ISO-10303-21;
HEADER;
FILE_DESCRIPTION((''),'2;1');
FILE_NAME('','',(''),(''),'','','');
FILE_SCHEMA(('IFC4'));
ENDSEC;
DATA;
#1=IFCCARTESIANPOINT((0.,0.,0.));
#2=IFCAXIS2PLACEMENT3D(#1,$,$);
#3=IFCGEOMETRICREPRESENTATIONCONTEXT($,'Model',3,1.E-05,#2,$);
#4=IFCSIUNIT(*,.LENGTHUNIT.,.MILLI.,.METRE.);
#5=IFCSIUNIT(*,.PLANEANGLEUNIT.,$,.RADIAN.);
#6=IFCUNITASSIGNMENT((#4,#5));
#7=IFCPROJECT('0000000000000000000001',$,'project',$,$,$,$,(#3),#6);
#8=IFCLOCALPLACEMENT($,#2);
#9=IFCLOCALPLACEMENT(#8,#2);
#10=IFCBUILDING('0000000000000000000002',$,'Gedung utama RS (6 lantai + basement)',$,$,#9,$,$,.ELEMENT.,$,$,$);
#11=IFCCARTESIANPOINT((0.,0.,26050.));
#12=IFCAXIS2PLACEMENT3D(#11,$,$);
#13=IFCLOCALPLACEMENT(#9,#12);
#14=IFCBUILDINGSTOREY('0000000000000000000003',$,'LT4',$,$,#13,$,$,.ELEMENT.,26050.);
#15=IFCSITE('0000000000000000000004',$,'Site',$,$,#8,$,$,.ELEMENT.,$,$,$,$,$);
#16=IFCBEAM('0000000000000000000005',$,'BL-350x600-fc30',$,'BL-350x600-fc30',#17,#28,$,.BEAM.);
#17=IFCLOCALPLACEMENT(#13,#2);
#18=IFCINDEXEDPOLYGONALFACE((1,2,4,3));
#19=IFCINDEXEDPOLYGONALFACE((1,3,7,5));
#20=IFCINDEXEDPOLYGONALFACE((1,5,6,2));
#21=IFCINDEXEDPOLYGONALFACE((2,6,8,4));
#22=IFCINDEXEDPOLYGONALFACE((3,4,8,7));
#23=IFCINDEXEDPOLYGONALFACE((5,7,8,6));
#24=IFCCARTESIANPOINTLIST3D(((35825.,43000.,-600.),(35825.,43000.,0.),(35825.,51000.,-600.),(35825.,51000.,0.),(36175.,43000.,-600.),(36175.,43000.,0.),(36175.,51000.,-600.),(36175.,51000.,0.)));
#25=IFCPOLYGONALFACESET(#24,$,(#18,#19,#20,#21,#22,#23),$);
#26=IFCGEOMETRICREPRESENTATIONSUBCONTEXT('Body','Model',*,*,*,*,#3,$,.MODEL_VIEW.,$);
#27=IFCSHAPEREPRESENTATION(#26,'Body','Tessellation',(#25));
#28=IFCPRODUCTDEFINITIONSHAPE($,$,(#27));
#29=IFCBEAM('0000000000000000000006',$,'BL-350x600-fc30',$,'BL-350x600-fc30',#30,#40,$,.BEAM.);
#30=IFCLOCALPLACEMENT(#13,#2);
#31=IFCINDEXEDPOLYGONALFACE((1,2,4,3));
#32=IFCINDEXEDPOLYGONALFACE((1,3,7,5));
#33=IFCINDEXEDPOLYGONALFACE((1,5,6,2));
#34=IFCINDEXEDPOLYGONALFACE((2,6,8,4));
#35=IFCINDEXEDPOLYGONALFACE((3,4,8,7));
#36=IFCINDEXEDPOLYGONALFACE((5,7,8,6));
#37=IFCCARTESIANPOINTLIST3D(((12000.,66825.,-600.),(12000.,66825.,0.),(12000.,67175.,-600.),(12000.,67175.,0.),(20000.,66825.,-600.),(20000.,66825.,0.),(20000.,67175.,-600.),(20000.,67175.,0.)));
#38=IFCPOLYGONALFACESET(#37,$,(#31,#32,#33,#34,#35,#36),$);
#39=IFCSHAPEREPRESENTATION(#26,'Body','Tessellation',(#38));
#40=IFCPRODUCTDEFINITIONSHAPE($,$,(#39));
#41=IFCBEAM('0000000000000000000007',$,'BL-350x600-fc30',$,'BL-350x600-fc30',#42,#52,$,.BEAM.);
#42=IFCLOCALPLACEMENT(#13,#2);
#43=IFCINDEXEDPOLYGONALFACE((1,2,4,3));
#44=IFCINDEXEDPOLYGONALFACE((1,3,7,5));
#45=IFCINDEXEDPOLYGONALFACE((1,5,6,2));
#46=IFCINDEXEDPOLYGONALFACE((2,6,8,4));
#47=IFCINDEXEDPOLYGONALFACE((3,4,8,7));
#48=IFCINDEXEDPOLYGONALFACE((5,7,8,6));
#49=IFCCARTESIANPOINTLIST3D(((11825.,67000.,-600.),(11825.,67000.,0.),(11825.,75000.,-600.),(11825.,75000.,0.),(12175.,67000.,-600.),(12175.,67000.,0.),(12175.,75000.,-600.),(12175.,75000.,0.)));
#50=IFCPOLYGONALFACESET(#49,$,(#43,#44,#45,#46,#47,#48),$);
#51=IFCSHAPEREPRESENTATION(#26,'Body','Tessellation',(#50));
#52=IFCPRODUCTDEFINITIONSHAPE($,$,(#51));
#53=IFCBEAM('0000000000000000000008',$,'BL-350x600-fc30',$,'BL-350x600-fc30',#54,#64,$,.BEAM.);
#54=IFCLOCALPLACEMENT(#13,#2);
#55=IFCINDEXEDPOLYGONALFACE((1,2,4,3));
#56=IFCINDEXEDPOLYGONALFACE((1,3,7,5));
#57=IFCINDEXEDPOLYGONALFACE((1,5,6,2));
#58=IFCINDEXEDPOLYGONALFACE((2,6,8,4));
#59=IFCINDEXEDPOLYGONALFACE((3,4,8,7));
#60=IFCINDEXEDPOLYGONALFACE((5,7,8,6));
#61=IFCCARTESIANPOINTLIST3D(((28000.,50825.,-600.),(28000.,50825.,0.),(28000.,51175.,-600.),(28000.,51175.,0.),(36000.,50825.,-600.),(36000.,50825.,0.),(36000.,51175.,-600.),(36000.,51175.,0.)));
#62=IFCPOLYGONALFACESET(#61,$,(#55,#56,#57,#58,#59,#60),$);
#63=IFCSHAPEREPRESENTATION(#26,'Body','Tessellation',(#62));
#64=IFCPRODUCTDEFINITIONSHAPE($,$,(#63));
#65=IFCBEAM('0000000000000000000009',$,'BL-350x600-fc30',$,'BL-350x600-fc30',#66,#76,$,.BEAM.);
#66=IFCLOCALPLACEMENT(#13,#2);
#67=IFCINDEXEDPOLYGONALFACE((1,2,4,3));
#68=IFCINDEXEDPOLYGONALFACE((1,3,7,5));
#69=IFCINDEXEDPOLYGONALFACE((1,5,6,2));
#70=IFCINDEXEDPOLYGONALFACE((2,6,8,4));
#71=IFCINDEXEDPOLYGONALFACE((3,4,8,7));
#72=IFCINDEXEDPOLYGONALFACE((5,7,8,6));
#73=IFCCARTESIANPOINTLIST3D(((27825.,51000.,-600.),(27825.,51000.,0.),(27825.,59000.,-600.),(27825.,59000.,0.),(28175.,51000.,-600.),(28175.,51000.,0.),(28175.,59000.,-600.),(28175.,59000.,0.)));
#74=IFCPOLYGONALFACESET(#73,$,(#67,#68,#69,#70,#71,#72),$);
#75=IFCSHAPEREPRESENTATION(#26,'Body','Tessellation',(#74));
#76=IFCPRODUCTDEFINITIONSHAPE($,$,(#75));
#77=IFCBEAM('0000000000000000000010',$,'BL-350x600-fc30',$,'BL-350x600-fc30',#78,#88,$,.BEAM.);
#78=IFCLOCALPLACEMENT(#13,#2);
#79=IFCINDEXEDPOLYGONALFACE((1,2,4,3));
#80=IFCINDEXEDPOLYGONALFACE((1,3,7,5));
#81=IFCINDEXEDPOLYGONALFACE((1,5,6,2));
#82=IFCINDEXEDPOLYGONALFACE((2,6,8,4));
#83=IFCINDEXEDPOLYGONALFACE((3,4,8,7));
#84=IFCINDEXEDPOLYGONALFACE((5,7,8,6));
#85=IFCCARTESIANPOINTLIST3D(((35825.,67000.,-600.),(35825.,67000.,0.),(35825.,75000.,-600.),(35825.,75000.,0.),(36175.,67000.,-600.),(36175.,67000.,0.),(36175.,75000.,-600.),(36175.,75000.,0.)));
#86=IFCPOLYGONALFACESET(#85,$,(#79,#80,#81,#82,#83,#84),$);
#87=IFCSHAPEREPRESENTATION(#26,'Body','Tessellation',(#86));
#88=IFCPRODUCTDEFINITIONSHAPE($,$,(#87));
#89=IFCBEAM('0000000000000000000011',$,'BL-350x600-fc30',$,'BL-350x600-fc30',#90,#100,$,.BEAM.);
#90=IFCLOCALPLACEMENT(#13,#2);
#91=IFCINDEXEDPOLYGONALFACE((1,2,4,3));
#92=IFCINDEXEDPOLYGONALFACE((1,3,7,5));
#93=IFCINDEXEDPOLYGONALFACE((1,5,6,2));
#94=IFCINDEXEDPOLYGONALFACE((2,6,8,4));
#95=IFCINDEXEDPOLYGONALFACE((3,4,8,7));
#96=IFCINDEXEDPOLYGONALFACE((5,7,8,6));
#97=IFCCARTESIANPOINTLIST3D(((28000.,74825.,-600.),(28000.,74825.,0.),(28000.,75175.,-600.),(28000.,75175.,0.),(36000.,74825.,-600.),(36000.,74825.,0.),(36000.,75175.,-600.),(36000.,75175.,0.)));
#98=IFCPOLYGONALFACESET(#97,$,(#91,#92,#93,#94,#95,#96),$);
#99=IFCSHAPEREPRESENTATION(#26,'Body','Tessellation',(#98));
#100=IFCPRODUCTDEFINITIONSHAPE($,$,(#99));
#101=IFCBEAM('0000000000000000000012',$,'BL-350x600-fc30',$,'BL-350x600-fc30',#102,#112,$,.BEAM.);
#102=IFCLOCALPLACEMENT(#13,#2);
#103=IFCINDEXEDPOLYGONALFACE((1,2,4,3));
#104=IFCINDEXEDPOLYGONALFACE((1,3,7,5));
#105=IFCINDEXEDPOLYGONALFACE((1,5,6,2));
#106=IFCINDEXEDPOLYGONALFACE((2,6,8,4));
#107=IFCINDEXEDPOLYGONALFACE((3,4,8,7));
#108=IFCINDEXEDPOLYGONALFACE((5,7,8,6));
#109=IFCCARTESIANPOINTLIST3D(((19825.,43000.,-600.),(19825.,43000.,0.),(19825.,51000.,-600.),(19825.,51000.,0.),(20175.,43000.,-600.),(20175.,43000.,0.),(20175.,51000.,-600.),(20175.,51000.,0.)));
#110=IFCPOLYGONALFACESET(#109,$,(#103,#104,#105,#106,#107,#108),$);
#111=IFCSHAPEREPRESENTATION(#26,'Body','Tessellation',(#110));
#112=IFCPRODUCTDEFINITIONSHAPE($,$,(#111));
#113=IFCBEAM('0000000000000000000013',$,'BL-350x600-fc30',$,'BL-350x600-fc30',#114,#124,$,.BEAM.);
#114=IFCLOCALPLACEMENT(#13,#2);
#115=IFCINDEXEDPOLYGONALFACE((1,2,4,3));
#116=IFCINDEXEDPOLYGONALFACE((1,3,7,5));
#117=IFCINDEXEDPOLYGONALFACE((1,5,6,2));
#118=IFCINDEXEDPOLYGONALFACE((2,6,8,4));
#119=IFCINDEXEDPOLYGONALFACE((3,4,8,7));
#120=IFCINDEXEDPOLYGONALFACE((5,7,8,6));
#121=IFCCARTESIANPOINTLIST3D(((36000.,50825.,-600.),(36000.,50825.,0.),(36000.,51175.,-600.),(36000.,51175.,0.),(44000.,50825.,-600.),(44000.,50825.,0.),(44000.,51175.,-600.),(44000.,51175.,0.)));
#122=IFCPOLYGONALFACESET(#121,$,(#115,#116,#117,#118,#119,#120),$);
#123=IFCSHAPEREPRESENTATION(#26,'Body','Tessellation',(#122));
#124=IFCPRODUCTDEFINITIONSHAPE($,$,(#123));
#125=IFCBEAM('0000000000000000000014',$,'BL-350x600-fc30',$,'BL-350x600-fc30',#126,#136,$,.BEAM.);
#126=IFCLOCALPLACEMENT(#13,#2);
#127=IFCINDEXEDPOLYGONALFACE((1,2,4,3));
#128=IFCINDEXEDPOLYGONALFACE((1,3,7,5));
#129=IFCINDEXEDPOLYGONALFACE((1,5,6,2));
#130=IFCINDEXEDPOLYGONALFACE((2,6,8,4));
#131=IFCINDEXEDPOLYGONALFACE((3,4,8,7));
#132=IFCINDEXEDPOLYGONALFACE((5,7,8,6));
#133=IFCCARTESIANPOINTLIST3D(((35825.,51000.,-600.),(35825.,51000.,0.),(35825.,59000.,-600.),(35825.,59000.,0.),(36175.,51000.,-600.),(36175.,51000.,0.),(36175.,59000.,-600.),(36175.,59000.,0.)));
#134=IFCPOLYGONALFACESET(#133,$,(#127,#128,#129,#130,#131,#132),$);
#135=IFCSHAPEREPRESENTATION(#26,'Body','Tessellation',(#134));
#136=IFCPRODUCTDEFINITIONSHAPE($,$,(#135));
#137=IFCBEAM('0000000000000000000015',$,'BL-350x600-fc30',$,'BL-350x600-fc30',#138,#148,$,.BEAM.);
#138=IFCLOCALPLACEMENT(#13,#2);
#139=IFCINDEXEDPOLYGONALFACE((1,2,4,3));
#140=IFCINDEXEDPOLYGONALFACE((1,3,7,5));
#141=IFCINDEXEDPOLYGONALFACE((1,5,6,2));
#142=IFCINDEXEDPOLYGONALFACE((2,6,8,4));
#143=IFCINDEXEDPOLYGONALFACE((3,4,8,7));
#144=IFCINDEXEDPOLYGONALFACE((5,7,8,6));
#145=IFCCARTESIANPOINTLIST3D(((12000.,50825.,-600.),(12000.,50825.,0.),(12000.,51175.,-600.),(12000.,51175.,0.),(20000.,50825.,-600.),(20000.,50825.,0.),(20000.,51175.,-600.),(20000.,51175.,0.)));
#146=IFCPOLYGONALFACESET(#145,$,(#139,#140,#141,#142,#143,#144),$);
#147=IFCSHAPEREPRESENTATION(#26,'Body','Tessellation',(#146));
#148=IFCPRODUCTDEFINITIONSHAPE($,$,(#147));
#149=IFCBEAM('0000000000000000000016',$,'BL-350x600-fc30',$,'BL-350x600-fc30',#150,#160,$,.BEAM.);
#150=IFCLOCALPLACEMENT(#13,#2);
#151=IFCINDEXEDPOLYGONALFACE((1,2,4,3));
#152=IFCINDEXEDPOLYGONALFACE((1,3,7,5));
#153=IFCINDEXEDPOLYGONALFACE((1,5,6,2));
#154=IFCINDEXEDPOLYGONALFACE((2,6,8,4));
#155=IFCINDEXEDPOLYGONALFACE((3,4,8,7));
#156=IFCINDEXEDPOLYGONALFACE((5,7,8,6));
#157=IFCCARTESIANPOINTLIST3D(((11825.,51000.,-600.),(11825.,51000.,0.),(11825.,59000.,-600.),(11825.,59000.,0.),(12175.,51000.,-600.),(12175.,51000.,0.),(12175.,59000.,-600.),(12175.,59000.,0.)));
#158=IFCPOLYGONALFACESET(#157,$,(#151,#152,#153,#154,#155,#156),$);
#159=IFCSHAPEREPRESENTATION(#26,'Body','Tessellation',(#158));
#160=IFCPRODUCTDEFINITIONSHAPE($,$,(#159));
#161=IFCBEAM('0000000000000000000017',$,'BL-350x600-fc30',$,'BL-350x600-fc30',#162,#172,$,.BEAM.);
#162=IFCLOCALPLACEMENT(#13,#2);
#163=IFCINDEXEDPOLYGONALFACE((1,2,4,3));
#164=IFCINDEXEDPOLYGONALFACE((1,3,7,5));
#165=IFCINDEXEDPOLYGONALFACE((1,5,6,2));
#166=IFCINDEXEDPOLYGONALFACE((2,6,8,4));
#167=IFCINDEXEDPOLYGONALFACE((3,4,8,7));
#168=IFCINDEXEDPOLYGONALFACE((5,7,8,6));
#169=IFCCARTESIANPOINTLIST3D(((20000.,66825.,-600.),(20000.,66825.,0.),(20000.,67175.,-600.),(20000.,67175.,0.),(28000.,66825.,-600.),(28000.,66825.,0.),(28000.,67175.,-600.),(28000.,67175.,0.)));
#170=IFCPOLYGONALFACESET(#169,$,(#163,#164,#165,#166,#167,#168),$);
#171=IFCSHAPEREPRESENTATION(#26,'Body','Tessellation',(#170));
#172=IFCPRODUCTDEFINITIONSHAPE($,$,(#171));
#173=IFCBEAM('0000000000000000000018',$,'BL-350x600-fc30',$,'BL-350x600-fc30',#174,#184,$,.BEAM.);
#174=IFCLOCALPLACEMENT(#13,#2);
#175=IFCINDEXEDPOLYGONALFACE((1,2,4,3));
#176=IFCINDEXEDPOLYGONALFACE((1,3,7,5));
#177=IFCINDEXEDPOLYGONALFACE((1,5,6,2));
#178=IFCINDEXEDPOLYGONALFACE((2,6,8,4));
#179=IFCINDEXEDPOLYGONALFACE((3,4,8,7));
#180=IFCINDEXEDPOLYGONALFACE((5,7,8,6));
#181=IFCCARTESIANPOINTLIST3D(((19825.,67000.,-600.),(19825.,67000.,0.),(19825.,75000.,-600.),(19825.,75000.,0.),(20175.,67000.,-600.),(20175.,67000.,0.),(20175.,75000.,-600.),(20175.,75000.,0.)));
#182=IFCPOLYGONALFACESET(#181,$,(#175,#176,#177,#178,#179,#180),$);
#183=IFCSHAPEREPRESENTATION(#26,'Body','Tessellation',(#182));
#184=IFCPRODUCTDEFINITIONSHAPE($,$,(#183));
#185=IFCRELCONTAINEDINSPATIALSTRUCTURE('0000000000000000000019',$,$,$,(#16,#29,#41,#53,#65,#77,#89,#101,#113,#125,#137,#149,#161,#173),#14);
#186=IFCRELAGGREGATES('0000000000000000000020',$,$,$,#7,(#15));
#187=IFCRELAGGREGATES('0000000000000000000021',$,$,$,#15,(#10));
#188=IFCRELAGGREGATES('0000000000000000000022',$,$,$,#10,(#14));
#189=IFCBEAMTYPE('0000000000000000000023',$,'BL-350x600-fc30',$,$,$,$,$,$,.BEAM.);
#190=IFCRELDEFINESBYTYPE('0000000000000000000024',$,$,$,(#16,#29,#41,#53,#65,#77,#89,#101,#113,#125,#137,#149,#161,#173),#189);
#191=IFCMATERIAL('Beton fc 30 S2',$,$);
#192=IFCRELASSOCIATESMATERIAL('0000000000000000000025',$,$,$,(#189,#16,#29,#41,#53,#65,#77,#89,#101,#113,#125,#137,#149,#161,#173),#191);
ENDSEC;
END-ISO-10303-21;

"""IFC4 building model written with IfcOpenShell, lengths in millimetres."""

from ifc_helpers import new_model, si_unit, frame, origin, origin_2d, place, context, subcontext, project, spatial, rectangle, extrude, material, material_profile, profile_set, profile_usage, type_object, element, save


model = new_model("IFC4")

# Units and contexts
model_context = context("Model", 3, precision=1e-05, world=origin())
body_context = subcontext(model_context, "Body", "Model", "MODEL_VIEW")
ifc_project = project(units=[si_unit("LENGTHUNIT", "METRE", prefix="MILLI"), si_unit("PLANEANGLEUNIT", "RADIAN")], contexts=[model_context])

# Site, building, storey
site_placement = place(None, origin())
site = spatial("IfcSite", under=ifc_project, at=site_placement, Name="Site", CompositionType="ELEMENT")
building_placement = place(site_placement, origin())
building = spatial("IfcBuilding", under=site, at=building_placement, Name="Gedung utama RS (6 lantai + basement)", CompositionType="ELEMENT")
storey_placement = place(building_placement, frame((0.0, 0.0, 26050.0)))
storey = spatial("IfcBuildingStorey", under=building, at=storey_placement, Name="LT4", CompositionType="ELEMENT", Elevation=26050.0)

# Beams
ifc_material = material(Name="Beton fc 30 S2")
ifc_material_profile_1 = material_profile(ifc_material, rectangle(XDim=350.0, YDim=600.0, at=origin_2d()), Name="BL-350x600-fc30")
ifc_profile_set_1 = profile_set([ifc_material_profile_1], Name="BL-350x600-fc30")
ifc_profile_usage_1 = profile_usage(ifc_profile_set_1, cardinal=8)
beam_type = type_object("IfcBeamType", Name="BL-350x600-fc30", PredefinedType="BEAM", material=ifc_profile_set_1)
beam_1_placement = place(storey_placement, frame((36000.0, 43000.0, -300.0)))
element("IfcBeam", 1, at=beam_1_placement, inside=storey, type_object=beam_type, material=ifc_profile_usage_1, Name="BL-350x600-fc30", ObjectType="BL-350x600-fc30", PredefinedType="BEAM", context=body_context, shape_type="SweptSolid", body=[
    extrude(rectangle(XDim=350.0, YDim=600.0, at=origin_2d()), frame((0.0, 0.0, 0.0), z_axis=(0.0, 1.0, 0.0), x_axis=(-1.0, 0.0, 0.0)), (0.0, 0.0, 1.0), 8000.0),
])
beam_2_placement = place(storey_placement, frame((12000.0, 67000.0, -300.0)))
element("IfcBeam", 2, at=beam_2_placement, inside=storey, type_object=beam_type, material=ifc_profile_usage_1, Name="BL-350x600-fc30", ObjectType="BL-350x600-fc30", PredefinedType="BEAM", context=body_context, shape_type="SweptSolid", body=[
    extrude(rectangle(XDim=350.0, YDim=600.0, at=origin_2d()), frame((0.0, 0.0, 0.0), z_axis=(1.0, 0.0, 0.0), x_axis=(0.0, 1.0, 0.0)), (0.0, 0.0, 1.0), 8000.0),
])
beam_3_placement = place(storey_placement, frame((12000.0, 67000.0, -300.0)))
element("IfcBeam", 3, at=beam_3_placement, inside=storey, type_object=beam_type, material=ifc_profile_usage_1, Name="BL-350x600-fc30", ObjectType="BL-350x600-fc30", PredefinedType="BEAM", context=body_context, shape_type="SweptSolid", body=[
    extrude(rectangle(XDim=350.0, YDim=600.0, at=origin_2d()), frame((0.0, 0.0, 0.0), z_axis=(0.0, 1.0, 0.0), x_axis=(-1.0, 0.0, 0.0)), (0.0, 0.0, 1.0), 8000.0),
])
beam_4_placement = place(storey_placement, frame((28000.0, 51000.0, -300.0)))
element("IfcBeam", 4, at=beam_4_placement, inside=storey, type_object=beam_type, material=ifc_profile_usage_1, Name="BL-350x600-fc30", ObjectType="BL-350x600-fc30", PredefinedType="BEAM", context=body_context, shape_type="SweptSolid", body=[
    extrude(rectangle(XDim=350.0, YDim=600.0, at=origin_2d()), frame((0.0, 0.0, 0.0), z_axis=(1.0, 0.0, 0.0), x_axis=(0.0, 1.0, 0.0)), (0.0, 0.0, 1.0), 8000.0),
])
for number, where, name in (
    (5, (28000.0, 51000.0, -300.0), "BL-350x600-fc30"),
    (6, (36000.0, 67000.0, -300.0), "BL-350x600-fc30"),
):
    element("IfcBeam", number, at=place(storey_placement, frame(where)), inside=storey, type_object=beam_type, material=ifc_profile_usage_1, Name=name, ObjectType="BL-350x600-fc30", PredefinedType="BEAM", context=body_context, shape_type="SweptSolid", body=[
        extrude(rectangle(XDim=350.0, YDim=600.0, at=origin_2d()), frame((0.0, 0.0, 0.0), z_axis=(0.0, 1.0, 0.0), x_axis=(-1.0, 0.0, 0.0)), (0.0, 0.0, 1.0), 8000.0),
    ])
beam_5_placement = place(storey_placement, frame((28000.0, 75000.0, -300.0)))
element("IfcBeam", 7, at=beam_5_placement, inside=storey, type_object=beam_type, material=ifc_profile_usage_1, Name="BL-350x600-fc30", ObjectType="BL-350x600-fc30", PredefinedType="BEAM", context=body_context, shape_type="SweptSolid", body=[
    extrude(rectangle(XDim=350.0, YDim=600.0, at=origin_2d()), frame((0.0, 0.0, 0.0), z_axis=(1.0, 0.0, 0.0), x_axis=(0.0, 1.0, 0.0)), (0.0, 0.0, 1.0), 8000.0),
])
beam_6_placement = place(storey_placement, frame((20000.0, 43000.0, -300.0)))
element("IfcBeam", 8, at=beam_6_placement, inside=storey, type_object=beam_type, material=ifc_profile_usage_1, Name="BL-350x600-fc30", ObjectType="BL-350x600-fc30", PredefinedType="BEAM", context=body_context, shape_type="SweptSolid", body=[
    extrude(rectangle(XDim=350.0, YDim=600.0, at=origin_2d()), frame((0.0, 0.0, 0.0), z_axis=(0.0, 1.0, 0.0), x_axis=(-1.0, 0.0, 0.0)), (0.0, 0.0, 1.0), 8000.0),
])
beam_7_placement = place(storey_placement, frame((36000.0, 51000.0, -300.0)))
element("IfcBeam", 9, at=beam_7_placement, inside=storey, type_object=beam_type, material=ifc_profile_usage_1, Name="BL-350x600-fc30", ObjectType="BL-350x600-fc30", PredefinedType="BEAM", context=body_context, shape_type="SweptSolid", body=[
    extrude(rectangle(XDim=350.0, YDim=600.0, at=origin_2d()), frame((0.0, 0.0, 0.0), z_axis=(1.0, 0.0, 0.0), x_axis=(0.0, 1.0, 0.0)), (0.0, 0.0, 1.0), 8000.0),
])
beam_8_placement = place(storey_placement, frame((36000.0, 51000.0, -300.0)))
element("IfcBeam", 10, at=beam_8_placement, inside=storey, type_object=beam_type, material=ifc_profile_usage_1, Name="BL-350x600-fc30", ObjectType="BL-350x600-fc30", PredefinedType="BEAM", context=body_context, shape_type="SweptSolid", body=[
    extrude(rectangle(XDim=350.0, YDim=600.0, at=origin_2d()), frame((0.0, 0.0, 0.0), z_axis=(0.0, 1.0, 0.0), x_axis=(-1.0, 0.0, 0.0)), (0.0, 0.0, 1.0), 8000.0),
])
beam_9_placement = place(storey_placement, frame((12000.0, 51000.0, -300.0)))
element("IfcBeam", 11, at=beam_9_placement, inside=storey, type_object=beam_type, material=ifc_profile_usage_1, Name="BL-350x600-fc30", ObjectType="BL-350x600-fc30", PredefinedType="BEAM", context=body_context, shape_type="SweptSolid", body=[
    extrude(rectangle(XDim=350.0, YDim=600.0, at=origin_2d()), frame((0.0, 0.0, 0.0), z_axis=(1.0, 0.0, 0.0), x_axis=(0.0, 1.0, 0.0)), (0.0, 0.0, 1.0), 8000.0),
])
beam_10_placement = place(storey_placement, frame((12000.0, 51000.0, -300.0)))
element("IfcBeam", 12, at=beam_10_placement, inside=storey, type_object=beam_type, material=ifc_profile_usage_1, Name="BL-350x600-fc30", ObjectType="BL-350x600-fc30", PredefinedType="BEAM", context=body_context, shape_type="SweptSolid", body=[
    extrude(rectangle(XDim=350.0, YDim=600.0, at=origin_2d()), frame((0.0, 0.0, 0.0), z_axis=(0.0, 1.0, 0.0), x_axis=(-1.0, 0.0, 0.0)), (0.0, 0.0, 1.0), 8000.0),
])
beam_11_placement = place(storey_placement, frame((20000.0, 67000.0, -300.0)))
element("IfcBeam", 13, at=beam_11_placement, inside=storey, type_object=beam_type, material=ifc_profile_usage_1, Name="BL-350x600-fc30", ObjectType="BL-350x600-fc30", PredefinedType="BEAM", context=body_context, shape_type="SweptSolid", body=[
    extrude(rectangle(XDim=350.0, YDim=600.0, at=origin_2d()), frame((0.0, 0.0, 0.0), z_axis=(1.0, 0.0, 0.0), x_axis=(0.0, 1.0, 0.0)), (0.0, 0.0, 1.0), 8000.0),
])
beam_12_placement = place(storey_placement, frame((20000.0, 67000.0, -300.0)))
element("IfcBeam", 14, at=beam_12_placement, inside=storey, type_object=beam_type, material=ifc_profile_usage_1, Name="BL-350x600-fc30", ObjectType="BL-350x600-fc30", PredefinedType="BEAM", context=body_context, shape_type="SweptSolid", body=[
    extrude(rectangle(XDim=350.0, YDim=600.0, at=origin_2d()), frame((0.0, 0.0, 0.0), z_axis=(0.0, 1.0, 0.0), x_axis=(-1.0, 0.0, 0.0)), (0.0, 0.0, 1.0), 8000.0),
])

save(model, "model.ifc")
